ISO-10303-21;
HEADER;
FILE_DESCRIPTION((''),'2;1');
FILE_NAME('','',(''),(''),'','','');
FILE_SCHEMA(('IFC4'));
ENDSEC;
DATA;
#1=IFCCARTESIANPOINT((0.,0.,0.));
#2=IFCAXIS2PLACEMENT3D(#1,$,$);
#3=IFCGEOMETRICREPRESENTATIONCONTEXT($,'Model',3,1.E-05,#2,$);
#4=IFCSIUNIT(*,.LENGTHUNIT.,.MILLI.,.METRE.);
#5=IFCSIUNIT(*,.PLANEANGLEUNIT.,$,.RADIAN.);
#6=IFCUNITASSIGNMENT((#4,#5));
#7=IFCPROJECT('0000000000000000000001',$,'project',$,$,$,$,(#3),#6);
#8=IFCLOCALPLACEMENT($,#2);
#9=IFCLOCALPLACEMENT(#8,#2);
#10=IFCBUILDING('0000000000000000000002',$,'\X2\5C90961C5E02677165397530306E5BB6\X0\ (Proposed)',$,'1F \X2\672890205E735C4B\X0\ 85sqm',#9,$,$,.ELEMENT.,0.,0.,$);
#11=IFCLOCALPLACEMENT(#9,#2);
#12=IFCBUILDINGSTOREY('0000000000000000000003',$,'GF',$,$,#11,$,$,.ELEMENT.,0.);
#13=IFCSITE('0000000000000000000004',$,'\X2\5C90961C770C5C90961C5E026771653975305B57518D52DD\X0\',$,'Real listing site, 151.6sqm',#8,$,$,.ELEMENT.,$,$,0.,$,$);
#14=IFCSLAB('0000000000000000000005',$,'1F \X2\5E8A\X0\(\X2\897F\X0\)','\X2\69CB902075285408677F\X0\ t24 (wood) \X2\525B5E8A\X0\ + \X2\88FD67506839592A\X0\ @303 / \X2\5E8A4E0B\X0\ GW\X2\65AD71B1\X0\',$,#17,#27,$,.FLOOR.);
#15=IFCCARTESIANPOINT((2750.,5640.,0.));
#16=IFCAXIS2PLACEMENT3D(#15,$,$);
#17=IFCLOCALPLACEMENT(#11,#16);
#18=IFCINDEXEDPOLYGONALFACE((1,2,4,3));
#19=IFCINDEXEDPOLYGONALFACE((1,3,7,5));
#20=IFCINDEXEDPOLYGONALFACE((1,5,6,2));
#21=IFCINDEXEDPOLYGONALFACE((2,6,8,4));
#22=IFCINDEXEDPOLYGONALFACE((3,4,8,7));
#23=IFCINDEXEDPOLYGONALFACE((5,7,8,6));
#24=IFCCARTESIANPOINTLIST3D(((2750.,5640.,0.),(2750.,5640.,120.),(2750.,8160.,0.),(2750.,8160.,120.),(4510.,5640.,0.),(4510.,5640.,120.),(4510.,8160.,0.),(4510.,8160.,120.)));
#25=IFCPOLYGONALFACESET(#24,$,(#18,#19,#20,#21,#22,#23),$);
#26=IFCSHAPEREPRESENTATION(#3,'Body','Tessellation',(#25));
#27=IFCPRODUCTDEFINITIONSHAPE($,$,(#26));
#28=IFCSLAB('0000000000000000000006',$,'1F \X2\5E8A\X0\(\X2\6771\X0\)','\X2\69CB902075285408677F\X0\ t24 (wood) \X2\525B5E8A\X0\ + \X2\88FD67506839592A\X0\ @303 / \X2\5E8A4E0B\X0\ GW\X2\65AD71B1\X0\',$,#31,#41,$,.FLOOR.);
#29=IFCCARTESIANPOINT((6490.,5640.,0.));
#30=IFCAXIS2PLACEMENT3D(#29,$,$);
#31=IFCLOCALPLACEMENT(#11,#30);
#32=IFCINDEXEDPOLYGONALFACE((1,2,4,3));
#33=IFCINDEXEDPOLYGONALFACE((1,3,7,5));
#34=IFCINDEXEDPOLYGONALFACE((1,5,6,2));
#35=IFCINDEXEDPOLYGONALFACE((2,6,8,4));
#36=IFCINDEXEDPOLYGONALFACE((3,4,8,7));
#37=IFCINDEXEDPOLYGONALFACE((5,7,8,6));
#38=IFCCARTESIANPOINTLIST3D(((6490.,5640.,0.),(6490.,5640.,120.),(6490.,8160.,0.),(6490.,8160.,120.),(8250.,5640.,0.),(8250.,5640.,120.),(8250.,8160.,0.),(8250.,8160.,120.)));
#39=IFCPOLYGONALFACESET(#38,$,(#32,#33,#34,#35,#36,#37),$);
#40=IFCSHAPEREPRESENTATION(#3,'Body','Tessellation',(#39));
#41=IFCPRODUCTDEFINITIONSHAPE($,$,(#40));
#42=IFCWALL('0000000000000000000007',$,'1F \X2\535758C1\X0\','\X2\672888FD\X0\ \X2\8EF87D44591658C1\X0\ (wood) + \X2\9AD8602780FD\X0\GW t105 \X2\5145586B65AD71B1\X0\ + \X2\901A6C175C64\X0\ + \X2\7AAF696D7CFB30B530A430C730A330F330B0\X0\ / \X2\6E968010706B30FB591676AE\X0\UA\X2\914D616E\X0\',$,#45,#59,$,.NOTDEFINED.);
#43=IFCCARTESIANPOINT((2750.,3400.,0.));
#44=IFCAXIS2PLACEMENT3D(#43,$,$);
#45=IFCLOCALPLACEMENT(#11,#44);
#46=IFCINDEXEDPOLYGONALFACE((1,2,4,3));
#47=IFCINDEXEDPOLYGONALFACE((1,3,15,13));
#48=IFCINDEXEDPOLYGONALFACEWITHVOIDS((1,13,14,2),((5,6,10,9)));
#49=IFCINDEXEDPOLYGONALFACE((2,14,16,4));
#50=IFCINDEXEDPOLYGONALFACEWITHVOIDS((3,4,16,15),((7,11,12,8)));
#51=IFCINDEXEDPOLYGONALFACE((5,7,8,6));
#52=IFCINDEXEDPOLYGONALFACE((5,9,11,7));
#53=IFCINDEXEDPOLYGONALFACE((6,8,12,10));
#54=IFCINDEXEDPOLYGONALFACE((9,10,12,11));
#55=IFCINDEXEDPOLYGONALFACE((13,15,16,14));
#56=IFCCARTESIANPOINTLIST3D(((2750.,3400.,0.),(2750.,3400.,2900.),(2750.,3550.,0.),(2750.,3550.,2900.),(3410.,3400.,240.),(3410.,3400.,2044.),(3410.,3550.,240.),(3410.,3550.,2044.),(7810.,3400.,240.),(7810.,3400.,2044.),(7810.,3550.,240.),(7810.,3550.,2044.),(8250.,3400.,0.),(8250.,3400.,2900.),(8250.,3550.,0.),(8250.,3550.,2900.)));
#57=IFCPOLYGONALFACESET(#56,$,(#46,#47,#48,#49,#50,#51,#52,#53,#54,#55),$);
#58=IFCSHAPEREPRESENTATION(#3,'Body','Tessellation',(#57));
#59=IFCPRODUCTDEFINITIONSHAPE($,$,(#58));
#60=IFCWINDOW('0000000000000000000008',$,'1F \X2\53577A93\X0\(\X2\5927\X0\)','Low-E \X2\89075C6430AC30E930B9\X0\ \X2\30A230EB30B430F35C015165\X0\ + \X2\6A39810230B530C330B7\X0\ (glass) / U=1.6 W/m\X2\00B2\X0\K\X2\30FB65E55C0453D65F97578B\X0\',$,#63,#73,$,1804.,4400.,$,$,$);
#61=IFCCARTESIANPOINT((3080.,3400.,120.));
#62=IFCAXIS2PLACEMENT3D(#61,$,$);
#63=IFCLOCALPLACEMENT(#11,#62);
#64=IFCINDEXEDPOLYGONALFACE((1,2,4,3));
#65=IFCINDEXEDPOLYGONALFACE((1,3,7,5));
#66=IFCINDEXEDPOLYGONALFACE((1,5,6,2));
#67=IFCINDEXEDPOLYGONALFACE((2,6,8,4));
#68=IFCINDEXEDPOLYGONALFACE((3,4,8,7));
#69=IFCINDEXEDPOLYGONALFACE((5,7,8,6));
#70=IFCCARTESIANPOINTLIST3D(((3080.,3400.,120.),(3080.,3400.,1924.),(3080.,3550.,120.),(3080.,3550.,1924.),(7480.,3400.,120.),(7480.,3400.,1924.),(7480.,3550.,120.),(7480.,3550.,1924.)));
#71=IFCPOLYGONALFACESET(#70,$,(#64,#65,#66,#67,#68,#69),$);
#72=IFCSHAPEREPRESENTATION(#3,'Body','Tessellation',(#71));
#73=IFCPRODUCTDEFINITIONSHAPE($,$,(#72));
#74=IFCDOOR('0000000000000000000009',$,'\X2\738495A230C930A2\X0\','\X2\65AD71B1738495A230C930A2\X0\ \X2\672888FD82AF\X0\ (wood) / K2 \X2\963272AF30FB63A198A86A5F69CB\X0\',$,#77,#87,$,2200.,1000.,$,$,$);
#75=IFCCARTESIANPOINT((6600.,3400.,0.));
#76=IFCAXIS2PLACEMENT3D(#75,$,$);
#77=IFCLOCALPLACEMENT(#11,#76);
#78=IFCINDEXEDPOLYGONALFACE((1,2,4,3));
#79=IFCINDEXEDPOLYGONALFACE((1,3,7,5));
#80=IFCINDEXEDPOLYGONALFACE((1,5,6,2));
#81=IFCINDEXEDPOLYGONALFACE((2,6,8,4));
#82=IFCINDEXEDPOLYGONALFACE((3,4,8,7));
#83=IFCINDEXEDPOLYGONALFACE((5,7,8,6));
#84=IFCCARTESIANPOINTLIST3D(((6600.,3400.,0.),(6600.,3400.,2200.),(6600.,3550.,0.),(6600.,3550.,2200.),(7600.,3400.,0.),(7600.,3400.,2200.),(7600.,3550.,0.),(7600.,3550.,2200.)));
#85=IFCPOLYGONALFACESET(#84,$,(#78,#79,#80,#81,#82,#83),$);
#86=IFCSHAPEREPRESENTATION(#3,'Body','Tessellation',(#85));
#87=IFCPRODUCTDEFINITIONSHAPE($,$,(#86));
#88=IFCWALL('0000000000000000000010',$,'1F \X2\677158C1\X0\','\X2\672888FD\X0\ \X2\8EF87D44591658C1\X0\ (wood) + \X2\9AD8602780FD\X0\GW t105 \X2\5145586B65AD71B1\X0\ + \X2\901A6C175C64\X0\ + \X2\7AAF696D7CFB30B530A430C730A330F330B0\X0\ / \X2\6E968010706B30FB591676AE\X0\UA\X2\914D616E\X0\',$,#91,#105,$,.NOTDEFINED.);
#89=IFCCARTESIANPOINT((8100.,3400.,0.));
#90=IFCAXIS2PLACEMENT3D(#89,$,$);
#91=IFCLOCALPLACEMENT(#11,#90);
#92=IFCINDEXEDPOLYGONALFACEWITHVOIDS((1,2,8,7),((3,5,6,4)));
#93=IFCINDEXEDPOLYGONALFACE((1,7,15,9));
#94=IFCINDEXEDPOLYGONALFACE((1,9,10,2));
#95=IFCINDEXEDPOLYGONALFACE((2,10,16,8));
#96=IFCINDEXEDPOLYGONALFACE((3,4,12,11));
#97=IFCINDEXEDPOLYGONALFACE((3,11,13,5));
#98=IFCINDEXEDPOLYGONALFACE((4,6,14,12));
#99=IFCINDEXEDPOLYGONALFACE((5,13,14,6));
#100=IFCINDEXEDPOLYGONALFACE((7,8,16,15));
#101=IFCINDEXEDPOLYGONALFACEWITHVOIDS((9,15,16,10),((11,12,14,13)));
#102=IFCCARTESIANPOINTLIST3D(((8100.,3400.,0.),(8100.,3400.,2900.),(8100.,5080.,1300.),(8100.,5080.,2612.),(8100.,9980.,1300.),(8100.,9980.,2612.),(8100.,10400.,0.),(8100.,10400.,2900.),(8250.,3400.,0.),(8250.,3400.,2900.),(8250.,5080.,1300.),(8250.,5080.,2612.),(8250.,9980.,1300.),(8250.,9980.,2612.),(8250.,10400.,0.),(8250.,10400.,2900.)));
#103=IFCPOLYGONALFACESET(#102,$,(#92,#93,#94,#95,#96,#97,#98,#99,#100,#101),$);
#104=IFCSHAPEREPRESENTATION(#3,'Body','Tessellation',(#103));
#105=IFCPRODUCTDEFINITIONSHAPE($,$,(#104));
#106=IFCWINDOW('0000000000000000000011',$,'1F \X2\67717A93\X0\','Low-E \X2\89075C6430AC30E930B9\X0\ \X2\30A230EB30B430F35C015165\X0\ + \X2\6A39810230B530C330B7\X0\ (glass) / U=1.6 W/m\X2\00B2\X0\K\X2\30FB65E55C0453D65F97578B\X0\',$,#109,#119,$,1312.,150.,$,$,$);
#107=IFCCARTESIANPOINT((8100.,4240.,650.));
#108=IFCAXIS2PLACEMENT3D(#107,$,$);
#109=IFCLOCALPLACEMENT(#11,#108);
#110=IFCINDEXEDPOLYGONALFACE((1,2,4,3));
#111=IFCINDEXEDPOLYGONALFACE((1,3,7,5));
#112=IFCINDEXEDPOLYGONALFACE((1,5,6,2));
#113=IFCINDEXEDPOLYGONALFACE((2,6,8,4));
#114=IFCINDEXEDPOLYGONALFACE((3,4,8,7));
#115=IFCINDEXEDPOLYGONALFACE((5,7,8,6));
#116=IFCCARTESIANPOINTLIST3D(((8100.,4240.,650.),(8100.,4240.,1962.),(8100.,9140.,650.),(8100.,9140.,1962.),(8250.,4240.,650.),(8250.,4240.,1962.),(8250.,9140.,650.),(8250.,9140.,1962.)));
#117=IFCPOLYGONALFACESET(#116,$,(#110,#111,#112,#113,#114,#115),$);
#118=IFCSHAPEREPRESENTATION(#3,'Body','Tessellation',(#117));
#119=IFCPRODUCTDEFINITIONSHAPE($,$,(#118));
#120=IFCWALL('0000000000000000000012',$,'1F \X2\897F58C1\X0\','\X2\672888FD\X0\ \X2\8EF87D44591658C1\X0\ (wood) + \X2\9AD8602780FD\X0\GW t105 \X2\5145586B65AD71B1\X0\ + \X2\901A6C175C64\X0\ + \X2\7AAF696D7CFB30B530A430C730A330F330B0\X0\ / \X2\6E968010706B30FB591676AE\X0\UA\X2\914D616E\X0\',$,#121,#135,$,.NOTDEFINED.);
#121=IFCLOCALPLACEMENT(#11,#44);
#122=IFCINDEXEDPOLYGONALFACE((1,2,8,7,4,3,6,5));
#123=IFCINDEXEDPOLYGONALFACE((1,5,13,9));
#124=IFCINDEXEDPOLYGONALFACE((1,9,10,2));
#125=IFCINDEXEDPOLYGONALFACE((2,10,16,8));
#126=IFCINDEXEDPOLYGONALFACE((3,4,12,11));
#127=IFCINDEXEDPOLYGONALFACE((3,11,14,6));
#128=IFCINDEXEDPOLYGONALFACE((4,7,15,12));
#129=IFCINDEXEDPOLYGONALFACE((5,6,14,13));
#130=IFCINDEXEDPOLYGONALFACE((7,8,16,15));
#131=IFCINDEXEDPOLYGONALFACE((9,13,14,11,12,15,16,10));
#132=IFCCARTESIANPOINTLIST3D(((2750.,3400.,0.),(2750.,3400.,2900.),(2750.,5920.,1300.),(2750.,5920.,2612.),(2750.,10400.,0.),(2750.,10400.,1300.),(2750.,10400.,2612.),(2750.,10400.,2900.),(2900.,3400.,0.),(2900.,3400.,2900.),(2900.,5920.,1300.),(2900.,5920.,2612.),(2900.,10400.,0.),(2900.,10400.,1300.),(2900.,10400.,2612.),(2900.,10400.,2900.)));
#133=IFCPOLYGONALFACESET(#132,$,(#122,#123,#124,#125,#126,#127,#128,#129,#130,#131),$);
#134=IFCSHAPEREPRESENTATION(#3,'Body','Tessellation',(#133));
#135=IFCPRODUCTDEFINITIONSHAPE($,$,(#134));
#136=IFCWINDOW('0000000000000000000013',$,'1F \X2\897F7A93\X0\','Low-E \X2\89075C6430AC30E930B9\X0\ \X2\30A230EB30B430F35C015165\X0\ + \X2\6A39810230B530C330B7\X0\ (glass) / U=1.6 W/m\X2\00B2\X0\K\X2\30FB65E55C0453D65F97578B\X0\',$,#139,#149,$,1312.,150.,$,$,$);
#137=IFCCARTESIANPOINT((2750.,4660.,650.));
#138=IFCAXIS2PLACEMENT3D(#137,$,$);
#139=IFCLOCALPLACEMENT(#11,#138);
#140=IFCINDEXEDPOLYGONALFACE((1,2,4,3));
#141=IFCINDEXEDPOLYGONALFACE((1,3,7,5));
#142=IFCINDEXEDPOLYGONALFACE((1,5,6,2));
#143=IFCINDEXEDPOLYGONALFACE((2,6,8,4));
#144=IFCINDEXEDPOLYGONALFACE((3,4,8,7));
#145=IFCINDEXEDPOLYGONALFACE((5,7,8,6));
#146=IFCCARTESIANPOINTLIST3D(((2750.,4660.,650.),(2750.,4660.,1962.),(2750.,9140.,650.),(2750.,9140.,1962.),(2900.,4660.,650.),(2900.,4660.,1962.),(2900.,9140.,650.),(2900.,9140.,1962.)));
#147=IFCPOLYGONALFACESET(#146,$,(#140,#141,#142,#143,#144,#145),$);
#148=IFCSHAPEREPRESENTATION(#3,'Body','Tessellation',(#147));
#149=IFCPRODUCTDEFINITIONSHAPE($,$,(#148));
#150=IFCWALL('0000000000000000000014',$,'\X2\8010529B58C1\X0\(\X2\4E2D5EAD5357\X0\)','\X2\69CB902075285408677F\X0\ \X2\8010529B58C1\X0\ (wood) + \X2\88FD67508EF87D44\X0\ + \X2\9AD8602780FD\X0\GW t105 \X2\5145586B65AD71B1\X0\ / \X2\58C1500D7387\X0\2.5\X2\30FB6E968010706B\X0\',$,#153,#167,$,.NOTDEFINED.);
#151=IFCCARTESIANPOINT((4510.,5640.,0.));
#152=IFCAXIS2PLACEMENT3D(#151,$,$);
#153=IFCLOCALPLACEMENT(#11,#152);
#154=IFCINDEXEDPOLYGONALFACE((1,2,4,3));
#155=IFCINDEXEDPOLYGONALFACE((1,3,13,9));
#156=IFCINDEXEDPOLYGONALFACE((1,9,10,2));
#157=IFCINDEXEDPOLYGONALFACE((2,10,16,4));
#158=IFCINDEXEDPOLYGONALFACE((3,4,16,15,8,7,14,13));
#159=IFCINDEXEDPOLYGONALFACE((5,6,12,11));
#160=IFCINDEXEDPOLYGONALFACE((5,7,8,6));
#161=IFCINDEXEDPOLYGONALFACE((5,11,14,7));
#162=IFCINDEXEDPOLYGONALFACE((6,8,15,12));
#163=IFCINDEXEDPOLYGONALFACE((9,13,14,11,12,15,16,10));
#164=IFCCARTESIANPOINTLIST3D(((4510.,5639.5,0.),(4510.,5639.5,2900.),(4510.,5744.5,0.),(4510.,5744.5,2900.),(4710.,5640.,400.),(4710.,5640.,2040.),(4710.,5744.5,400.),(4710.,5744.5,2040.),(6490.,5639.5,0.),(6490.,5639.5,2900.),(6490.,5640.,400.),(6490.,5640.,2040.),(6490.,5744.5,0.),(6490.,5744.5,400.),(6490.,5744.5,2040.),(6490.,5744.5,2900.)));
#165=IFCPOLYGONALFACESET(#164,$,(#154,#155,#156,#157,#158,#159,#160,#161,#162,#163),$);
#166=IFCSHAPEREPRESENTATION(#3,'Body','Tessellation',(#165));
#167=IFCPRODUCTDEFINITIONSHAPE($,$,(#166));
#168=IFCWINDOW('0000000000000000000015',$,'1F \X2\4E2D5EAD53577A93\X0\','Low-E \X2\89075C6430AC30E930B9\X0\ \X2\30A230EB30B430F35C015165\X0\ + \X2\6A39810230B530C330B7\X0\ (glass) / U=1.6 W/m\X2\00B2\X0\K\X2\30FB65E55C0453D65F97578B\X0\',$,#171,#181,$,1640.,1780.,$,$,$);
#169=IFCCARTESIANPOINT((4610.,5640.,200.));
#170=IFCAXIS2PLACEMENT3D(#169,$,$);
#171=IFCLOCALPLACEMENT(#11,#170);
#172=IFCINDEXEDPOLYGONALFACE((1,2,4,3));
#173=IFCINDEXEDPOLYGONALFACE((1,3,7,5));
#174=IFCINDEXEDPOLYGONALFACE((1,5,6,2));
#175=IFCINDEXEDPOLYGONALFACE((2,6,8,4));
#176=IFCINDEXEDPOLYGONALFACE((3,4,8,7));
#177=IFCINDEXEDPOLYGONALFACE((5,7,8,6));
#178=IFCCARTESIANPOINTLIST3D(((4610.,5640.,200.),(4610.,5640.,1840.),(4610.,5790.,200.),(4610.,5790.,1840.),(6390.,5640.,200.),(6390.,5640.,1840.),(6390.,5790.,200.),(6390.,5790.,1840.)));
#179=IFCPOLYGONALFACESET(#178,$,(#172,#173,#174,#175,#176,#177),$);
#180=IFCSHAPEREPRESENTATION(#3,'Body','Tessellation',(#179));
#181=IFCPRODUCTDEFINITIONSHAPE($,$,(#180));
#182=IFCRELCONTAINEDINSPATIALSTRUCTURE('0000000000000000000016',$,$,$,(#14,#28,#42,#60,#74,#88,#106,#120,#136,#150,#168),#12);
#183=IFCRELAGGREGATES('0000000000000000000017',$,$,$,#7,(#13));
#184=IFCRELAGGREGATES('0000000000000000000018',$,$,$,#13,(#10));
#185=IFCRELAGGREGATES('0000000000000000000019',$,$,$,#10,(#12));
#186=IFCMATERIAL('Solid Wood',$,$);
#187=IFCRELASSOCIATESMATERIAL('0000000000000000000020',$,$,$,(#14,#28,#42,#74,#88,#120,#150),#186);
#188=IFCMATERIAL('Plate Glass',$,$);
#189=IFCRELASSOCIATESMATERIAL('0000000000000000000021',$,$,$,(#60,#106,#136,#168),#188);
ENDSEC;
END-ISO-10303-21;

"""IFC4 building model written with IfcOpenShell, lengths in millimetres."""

from ifc_helpers import new_model, si_unit, frame, frame_2d, origin, place, context, project, spatial, rectangle, extrude, material, element, fill, save


model = new_model("IFC4")

# Units and contexts
model_context = context("Model", 3, precision=1e-05, world=origin())
ifc_project = project(units=[si_unit("LENGTHUNIT", "METRE", prefix="MILLI"), si_unit("PLANEANGLEUNIT", "RADIAN")], contexts=[model_context])

# Site, building, storey
site_placement = place(None, origin())
site = spatial("IfcSite", under=ifc_project, at=site_placement, Name="岐阜県岐阜市東改田字再勝", ObjectType="Real listing site, 151.6sqm", CompositionType="ELEMENT", RefElevation=0.0)
building_placement = place(site_placement, origin())
building = spatial("IfcBuilding", under=site, at=building_placement, Name="岐阜市東改田の家 (Proposed)", ObjectType="1F 木造平屋 85sqm", CompositionType="ELEMENT", ElevationOfRefHeight=0.0, ElevationOfTerrain=0.0)
storey_placement = place(building_placement, origin())
storey = spatial("IfcBuildingStorey", under=building, at=storey_placement, Name="GF", CompositionType="ELEMENT", Elevation=0.0)

# Slabs
ifc_material_1 = material(Name="Solid Wood")
slab_1_placement = place(storey_placement, frame((2750.0, 5640.0, 0.0)))
element("IfcSlab", 1, at=slab_1_placement, inside=storey, material=ifc_material_1, Name="1F 床(西)", Description="構造用合板 t24 (wood) 剛床 + 製材根太 @303 / 床下 GW断熱", PredefinedType="FLOOR", context=model_context, shape_type="SweptSolid", body=[
    extrude(rectangle(XDim=1760.0, YDim=2520.0, at=frame_2d((880.0, 1260.0))), frame((2750.0, 5640.0, 0.0)), (0.0, 0.0, 1.0), 120.0),
])
slab_2_placement = place(storey_placement, frame((6490.0, 5640.0, 0.0)))
element("IfcSlab", 2, at=slab_2_placement, inside=storey, material=ifc_material_1, Name="1F 床(東)", Description="構造用合板 t24 (wood) 剛床 + 製材根太 @303 / 床下 GW断熱", PredefinedType="FLOOR", context=model_context, shape_type="SweptSolid", body=[
    extrude(rectangle(XDim=1760.0, YDim=2520.0, at=frame_2d((880.0, 1260.0))), frame((6490.0, 5640.0, 0.0)), (0.0, 0.0, 1.0), 120.0),
])

# Wall, openings, window, door
wall_1_placement = place(storey_placement, frame((2750.0, 3400.0, 0.0)))
wall_1 = element("IfcWall", 3, at=wall_1_placement, inside=storey, material=ifc_material_1, Name="1F 南壁", Description="木製 軸組外壁 (wood) + 高性能GW t105 充填断熱 + 通気層 + 窯業系サイディング / 準耐火・外皮UA配慮", PredefinedType="NOTDEFINED", context=model_context, shape_type="SweptSolid", body=[
    extrude(rectangle(XDim=5500.0, YDim=150.0, at=frame_2d((2750.0, 75.0))), frame((2750.0, 3400.0, 0.0)), (0.0, 0.0, 1.0), 2900.0),
])
opening_1_placement = place(storey_placement, frame((3080.0, 3400.0, 120.0)))
opening_1 = element("IfcOpeningElement", 4, at=opening_1_placement, cuts=wall_1, PredefinedType="NOTDEFINED", context=model_context, shape_type="SweptSolid", body=[
    extrude(rectangle(XDim=4400.0, YDim=150.0, at=frame_2d((2200.0, 75.0))), frame((3080.0, 3400.0, 120.0)), (0.0, 0.0, 1.0), 1804.0),
])
opening_2_placement = place(storey_placement, frame((6600.0, 3400.0, 0.0)))
opening_2 = element("IfcOpeningElement", 5, at=opening_2_placement, cuts=wall_1, PredefinedType="NOTDEFINED", context=model_context, shape_type="SweptSolid", body=[
    extrude(rectangle(XDim=1000.0, YDim=150.0, at=frame_2d((500.0, 75.0))), frame((6600.0, 3400.0, 0.0)), (0.0, 0.0, 1.0), 2200.0),
])
ifc_material_2 = material(Name="Plate Glass")
window_1_placement = place(storey_placement, frame((3080.0, 3400.0, 120.0)))
window_1 = element("IfcWindow", 6, at=window_1_placement, inside=storey, material=ifc_material_2, Name="1F 南窓(大)", Description="Low-E 複層ガラス アルゴン封入 + 樹脂サッシ (glass) / U=1.6 W/m²K・日射取得型", OverallHeight=1804.0, OverallWidth=4400.0, context=model_context, shape_type="SweptSolid", body=[
    extrude(rectangle(XDim=4400.0, YDim=150.0, at=frame_2d((2200.0, 75.0))), frame((3080.0, 3400.0, 120.0)), (0.0, 0.0, 1.0), 1804.0),
])
fill(opening_1, window_1)
door_placement = place(storey_placement, frame((6600.0, 3400.0, 0.0)))
door = element("IfcDoor", 7, at=door_placement, inside=storey, material=ifc_material_1, Name="玄関ドア", Description="断熱玄関ドア 木製芯 (wood) / K2 防犯・採風機構", OverallHeight=2200.0, OverallWidth=1000.0, context=model_context, shape_type="SweptSolid", body=[
    extrude(rectangle(XDim=1000.0, YDim=150.0, at=frame_2d((500.0, 75.0))), frame((6600.0, 3400.0, 0.0)), (0.0, 0.0, 1.0), 2200.0),
])
fill(opening_2, door)

# Walls, openings, windows
wall_2_placement = place(storey_placement, frame((8100.0, 3400.0, 0.0)))
wall_2 = element("IfcWall", 8, at=wall_2_placement, inside=storey, material=ifc_material_1, Name="1F 東壁", Description="木製 軸組外壁 (wood) + 高性能GW t105 充填断熱 + 通気層 + 窯業系サイディング / 準耐火・外皮UA配慮", PredefinedType="NOTDEFINED", context=model_context, shape_type="SweptSolid", body=[
    extrude(rectangle(XDim=150.0, YDim=7000.0, at=frame_2d((75.0, 3500.0))), frame((8100.0, 3400.0, 0.0)), (0.0, 0.0, 1.0), 2900.0),
])
opening_3_placement = place(storey_placement, frame((8100.0, 4240.0, 650.0)))
opening_3 = element("IfcOpeningElement", 9, at=opening_3_placement, cuts=wall_2, PredefinedType="NOTDEFINED", context=model_context, shape_type="SweptSolid", body=[
    extrude(rectangle(XDim=150.0, YDim=4900.0, at=frame_2d((75.0, 2450.0))), frame((8100.0, 4240.0, 650.0)), (0.0, 0.0, 1.0), 1312.0),
])
window_2_placement = place(storey_placement, frame((8100.0, 4240.0, 650.0)))
window_2 = element("IfcWindow", 10, at=window_2_placement, inside=storey, material=ifc_material_2, Name="1F 東窓", Description="Low-E 複層ガラス アルゴン封入 + 樹脂サッシ (glass) / U=1.6 W/m²K・日射取得型", OverallHeight=1312.0, OverallWidth=150.0, context=model_context, shape_type="SweptSolid", body=[
    extrude(rectangle(XDim=150.0, YDim=4900.0, at=frame_2d((75.0, 2450.0))), frame((8100.0, 4240.0, 650.0)), (0.0, 0.0, 1.0), 1312.0),
])
fill(opening_3, window_2)
wall_3_placement = place(storey_placement, frame((2750.0, 3400.0, 0.0)))
wall_3 = element("IfcWall", 11, at=wall_3_placement, inside=storey, material=ifc_material_1, Name="1F 西壁", Description="木製 軸組外壁 (wood) + 高性能GW t105 充填断熱 + 通気層 + 窯業系サイディング / 準耐火・外皮UA配慮", PredefinedType="NOTDEFINED", context=model_context, shape_type="SweptSolid", body=[
    extrude(rectangle(XDim=150.0, YDim=7000.0, at=frame_2d((75.0, 3500.0))), frame((2750.0, 3400.0, 0.0)), (0.0, 0.0, 1.0), 2900.0),
])
opening_4_placement = place(storey_placement, frame((2750.0, 4660.0, 650.0)))
opening_4 = element("IfcOpeningElement", 12, at=opening_4_placement, cuts=wall_3, PredefinedType="NOTDEFINED", context=model_context, shape_type="SweptSolid", body=[
    extrude(rectangle(XDim=150.0, YDim=4480.0, at=frame_2d((75.0, 2240.0))), frame((2750.0, 4660.0, 650.0)), (0.0, 0.0, 1.0), 1312.0),
])
window_3_placement = place(storey_placement, frame((2750.0, 4660.0, 650.0)))
window_3 = element("IfcWindow", 13, at=window_3_placement, inside=storey, material=ifc_material_2, Name="1F 西窓", Description="Low-E 複層ガラス アルゴン封入 + 樹脂サッシ (glass) / U=1.6 W/m²K・日射取得型", OverallHeight=1312.0, OverallWidth=150.0, context=model_context, shape_type="SweptSolid", body=[
    extrude(rectangle(XDim=150.0, YDim=4480.0, at=frame_2d((75.0, 2240.0))), frame((2750.0, 4660.0, 650.0)), (0.0, 0.0, 1.0), 1312.0),
])
fill(opening_4, window_3)
wall_4_placement = place(storey_placement, frame((4510.0, 5640.0, 0.0)))
wall_4 = element("IfcWall", 14, at=wall_4_placement, inside=storey, material=ifc_material_1, Name="耐力壁(中庭南)", Description="構造用合板 耐力壁 (wood) + 製材軸組 + 高性能GW t105 充填断熱 / 壁倍率2.5・準耐火", PredefinedType="NOTDEFINED", context=model_context, shape_type="SweptSolid", body=[
    extrude(rectangle(XDim=1980.0, YDim=105.0, at=frame_2d((990.0, 52.0))), frame((4510.0, 5640.0, 0.0)), (0.0, 0.0, 1.0), 2900.0),
])
opening_5_placement = place(storey_placement, frame((4610.0, 5640.0, 200.0)))
opening_5 = element("IfcOpeningElement", 15, at=opening_5_placement, cuts=wall_4, PredefinedType="NOTDEFINED", context=model_context, shape_type="SweptSolid", body=[
    extrude(rectangle(XDim=1780.0, YDim=150.0, at=frame_2d((890.0, 75.0))), frame((4610.0, 5640.0, 200.0)), (0.0, 0.0, 1.0), 1640.0),
])
window_4_placement = place(storey_placement, frame((4610.0, 5640.0, 200.0)))
window_4 = element("IfcWindow", 16, at=window_4_placement, inside=storey, material=ifc_material_2, Name="1F 中庭南窓", Description="Low-E 複層ガラス アルゴン封入 + 樹脂サッシ (glass) / U=1.6 W/m²K・日射取得型", OverallHeight=1640.0, OverallWidth=1780.0, context=model_context, shape_type="SweptSolid", body=[
    extrude(rectangle(XDim=1780.0, YDim=150.0, at=frame_2d((890.0, 75.0))), frame((4610.0, 5640.0, 200.0)), (0.0, 0.0, 1.0), 1640.0),
])
fill(opening_5, window_4)

save(model, "model.ifc")
